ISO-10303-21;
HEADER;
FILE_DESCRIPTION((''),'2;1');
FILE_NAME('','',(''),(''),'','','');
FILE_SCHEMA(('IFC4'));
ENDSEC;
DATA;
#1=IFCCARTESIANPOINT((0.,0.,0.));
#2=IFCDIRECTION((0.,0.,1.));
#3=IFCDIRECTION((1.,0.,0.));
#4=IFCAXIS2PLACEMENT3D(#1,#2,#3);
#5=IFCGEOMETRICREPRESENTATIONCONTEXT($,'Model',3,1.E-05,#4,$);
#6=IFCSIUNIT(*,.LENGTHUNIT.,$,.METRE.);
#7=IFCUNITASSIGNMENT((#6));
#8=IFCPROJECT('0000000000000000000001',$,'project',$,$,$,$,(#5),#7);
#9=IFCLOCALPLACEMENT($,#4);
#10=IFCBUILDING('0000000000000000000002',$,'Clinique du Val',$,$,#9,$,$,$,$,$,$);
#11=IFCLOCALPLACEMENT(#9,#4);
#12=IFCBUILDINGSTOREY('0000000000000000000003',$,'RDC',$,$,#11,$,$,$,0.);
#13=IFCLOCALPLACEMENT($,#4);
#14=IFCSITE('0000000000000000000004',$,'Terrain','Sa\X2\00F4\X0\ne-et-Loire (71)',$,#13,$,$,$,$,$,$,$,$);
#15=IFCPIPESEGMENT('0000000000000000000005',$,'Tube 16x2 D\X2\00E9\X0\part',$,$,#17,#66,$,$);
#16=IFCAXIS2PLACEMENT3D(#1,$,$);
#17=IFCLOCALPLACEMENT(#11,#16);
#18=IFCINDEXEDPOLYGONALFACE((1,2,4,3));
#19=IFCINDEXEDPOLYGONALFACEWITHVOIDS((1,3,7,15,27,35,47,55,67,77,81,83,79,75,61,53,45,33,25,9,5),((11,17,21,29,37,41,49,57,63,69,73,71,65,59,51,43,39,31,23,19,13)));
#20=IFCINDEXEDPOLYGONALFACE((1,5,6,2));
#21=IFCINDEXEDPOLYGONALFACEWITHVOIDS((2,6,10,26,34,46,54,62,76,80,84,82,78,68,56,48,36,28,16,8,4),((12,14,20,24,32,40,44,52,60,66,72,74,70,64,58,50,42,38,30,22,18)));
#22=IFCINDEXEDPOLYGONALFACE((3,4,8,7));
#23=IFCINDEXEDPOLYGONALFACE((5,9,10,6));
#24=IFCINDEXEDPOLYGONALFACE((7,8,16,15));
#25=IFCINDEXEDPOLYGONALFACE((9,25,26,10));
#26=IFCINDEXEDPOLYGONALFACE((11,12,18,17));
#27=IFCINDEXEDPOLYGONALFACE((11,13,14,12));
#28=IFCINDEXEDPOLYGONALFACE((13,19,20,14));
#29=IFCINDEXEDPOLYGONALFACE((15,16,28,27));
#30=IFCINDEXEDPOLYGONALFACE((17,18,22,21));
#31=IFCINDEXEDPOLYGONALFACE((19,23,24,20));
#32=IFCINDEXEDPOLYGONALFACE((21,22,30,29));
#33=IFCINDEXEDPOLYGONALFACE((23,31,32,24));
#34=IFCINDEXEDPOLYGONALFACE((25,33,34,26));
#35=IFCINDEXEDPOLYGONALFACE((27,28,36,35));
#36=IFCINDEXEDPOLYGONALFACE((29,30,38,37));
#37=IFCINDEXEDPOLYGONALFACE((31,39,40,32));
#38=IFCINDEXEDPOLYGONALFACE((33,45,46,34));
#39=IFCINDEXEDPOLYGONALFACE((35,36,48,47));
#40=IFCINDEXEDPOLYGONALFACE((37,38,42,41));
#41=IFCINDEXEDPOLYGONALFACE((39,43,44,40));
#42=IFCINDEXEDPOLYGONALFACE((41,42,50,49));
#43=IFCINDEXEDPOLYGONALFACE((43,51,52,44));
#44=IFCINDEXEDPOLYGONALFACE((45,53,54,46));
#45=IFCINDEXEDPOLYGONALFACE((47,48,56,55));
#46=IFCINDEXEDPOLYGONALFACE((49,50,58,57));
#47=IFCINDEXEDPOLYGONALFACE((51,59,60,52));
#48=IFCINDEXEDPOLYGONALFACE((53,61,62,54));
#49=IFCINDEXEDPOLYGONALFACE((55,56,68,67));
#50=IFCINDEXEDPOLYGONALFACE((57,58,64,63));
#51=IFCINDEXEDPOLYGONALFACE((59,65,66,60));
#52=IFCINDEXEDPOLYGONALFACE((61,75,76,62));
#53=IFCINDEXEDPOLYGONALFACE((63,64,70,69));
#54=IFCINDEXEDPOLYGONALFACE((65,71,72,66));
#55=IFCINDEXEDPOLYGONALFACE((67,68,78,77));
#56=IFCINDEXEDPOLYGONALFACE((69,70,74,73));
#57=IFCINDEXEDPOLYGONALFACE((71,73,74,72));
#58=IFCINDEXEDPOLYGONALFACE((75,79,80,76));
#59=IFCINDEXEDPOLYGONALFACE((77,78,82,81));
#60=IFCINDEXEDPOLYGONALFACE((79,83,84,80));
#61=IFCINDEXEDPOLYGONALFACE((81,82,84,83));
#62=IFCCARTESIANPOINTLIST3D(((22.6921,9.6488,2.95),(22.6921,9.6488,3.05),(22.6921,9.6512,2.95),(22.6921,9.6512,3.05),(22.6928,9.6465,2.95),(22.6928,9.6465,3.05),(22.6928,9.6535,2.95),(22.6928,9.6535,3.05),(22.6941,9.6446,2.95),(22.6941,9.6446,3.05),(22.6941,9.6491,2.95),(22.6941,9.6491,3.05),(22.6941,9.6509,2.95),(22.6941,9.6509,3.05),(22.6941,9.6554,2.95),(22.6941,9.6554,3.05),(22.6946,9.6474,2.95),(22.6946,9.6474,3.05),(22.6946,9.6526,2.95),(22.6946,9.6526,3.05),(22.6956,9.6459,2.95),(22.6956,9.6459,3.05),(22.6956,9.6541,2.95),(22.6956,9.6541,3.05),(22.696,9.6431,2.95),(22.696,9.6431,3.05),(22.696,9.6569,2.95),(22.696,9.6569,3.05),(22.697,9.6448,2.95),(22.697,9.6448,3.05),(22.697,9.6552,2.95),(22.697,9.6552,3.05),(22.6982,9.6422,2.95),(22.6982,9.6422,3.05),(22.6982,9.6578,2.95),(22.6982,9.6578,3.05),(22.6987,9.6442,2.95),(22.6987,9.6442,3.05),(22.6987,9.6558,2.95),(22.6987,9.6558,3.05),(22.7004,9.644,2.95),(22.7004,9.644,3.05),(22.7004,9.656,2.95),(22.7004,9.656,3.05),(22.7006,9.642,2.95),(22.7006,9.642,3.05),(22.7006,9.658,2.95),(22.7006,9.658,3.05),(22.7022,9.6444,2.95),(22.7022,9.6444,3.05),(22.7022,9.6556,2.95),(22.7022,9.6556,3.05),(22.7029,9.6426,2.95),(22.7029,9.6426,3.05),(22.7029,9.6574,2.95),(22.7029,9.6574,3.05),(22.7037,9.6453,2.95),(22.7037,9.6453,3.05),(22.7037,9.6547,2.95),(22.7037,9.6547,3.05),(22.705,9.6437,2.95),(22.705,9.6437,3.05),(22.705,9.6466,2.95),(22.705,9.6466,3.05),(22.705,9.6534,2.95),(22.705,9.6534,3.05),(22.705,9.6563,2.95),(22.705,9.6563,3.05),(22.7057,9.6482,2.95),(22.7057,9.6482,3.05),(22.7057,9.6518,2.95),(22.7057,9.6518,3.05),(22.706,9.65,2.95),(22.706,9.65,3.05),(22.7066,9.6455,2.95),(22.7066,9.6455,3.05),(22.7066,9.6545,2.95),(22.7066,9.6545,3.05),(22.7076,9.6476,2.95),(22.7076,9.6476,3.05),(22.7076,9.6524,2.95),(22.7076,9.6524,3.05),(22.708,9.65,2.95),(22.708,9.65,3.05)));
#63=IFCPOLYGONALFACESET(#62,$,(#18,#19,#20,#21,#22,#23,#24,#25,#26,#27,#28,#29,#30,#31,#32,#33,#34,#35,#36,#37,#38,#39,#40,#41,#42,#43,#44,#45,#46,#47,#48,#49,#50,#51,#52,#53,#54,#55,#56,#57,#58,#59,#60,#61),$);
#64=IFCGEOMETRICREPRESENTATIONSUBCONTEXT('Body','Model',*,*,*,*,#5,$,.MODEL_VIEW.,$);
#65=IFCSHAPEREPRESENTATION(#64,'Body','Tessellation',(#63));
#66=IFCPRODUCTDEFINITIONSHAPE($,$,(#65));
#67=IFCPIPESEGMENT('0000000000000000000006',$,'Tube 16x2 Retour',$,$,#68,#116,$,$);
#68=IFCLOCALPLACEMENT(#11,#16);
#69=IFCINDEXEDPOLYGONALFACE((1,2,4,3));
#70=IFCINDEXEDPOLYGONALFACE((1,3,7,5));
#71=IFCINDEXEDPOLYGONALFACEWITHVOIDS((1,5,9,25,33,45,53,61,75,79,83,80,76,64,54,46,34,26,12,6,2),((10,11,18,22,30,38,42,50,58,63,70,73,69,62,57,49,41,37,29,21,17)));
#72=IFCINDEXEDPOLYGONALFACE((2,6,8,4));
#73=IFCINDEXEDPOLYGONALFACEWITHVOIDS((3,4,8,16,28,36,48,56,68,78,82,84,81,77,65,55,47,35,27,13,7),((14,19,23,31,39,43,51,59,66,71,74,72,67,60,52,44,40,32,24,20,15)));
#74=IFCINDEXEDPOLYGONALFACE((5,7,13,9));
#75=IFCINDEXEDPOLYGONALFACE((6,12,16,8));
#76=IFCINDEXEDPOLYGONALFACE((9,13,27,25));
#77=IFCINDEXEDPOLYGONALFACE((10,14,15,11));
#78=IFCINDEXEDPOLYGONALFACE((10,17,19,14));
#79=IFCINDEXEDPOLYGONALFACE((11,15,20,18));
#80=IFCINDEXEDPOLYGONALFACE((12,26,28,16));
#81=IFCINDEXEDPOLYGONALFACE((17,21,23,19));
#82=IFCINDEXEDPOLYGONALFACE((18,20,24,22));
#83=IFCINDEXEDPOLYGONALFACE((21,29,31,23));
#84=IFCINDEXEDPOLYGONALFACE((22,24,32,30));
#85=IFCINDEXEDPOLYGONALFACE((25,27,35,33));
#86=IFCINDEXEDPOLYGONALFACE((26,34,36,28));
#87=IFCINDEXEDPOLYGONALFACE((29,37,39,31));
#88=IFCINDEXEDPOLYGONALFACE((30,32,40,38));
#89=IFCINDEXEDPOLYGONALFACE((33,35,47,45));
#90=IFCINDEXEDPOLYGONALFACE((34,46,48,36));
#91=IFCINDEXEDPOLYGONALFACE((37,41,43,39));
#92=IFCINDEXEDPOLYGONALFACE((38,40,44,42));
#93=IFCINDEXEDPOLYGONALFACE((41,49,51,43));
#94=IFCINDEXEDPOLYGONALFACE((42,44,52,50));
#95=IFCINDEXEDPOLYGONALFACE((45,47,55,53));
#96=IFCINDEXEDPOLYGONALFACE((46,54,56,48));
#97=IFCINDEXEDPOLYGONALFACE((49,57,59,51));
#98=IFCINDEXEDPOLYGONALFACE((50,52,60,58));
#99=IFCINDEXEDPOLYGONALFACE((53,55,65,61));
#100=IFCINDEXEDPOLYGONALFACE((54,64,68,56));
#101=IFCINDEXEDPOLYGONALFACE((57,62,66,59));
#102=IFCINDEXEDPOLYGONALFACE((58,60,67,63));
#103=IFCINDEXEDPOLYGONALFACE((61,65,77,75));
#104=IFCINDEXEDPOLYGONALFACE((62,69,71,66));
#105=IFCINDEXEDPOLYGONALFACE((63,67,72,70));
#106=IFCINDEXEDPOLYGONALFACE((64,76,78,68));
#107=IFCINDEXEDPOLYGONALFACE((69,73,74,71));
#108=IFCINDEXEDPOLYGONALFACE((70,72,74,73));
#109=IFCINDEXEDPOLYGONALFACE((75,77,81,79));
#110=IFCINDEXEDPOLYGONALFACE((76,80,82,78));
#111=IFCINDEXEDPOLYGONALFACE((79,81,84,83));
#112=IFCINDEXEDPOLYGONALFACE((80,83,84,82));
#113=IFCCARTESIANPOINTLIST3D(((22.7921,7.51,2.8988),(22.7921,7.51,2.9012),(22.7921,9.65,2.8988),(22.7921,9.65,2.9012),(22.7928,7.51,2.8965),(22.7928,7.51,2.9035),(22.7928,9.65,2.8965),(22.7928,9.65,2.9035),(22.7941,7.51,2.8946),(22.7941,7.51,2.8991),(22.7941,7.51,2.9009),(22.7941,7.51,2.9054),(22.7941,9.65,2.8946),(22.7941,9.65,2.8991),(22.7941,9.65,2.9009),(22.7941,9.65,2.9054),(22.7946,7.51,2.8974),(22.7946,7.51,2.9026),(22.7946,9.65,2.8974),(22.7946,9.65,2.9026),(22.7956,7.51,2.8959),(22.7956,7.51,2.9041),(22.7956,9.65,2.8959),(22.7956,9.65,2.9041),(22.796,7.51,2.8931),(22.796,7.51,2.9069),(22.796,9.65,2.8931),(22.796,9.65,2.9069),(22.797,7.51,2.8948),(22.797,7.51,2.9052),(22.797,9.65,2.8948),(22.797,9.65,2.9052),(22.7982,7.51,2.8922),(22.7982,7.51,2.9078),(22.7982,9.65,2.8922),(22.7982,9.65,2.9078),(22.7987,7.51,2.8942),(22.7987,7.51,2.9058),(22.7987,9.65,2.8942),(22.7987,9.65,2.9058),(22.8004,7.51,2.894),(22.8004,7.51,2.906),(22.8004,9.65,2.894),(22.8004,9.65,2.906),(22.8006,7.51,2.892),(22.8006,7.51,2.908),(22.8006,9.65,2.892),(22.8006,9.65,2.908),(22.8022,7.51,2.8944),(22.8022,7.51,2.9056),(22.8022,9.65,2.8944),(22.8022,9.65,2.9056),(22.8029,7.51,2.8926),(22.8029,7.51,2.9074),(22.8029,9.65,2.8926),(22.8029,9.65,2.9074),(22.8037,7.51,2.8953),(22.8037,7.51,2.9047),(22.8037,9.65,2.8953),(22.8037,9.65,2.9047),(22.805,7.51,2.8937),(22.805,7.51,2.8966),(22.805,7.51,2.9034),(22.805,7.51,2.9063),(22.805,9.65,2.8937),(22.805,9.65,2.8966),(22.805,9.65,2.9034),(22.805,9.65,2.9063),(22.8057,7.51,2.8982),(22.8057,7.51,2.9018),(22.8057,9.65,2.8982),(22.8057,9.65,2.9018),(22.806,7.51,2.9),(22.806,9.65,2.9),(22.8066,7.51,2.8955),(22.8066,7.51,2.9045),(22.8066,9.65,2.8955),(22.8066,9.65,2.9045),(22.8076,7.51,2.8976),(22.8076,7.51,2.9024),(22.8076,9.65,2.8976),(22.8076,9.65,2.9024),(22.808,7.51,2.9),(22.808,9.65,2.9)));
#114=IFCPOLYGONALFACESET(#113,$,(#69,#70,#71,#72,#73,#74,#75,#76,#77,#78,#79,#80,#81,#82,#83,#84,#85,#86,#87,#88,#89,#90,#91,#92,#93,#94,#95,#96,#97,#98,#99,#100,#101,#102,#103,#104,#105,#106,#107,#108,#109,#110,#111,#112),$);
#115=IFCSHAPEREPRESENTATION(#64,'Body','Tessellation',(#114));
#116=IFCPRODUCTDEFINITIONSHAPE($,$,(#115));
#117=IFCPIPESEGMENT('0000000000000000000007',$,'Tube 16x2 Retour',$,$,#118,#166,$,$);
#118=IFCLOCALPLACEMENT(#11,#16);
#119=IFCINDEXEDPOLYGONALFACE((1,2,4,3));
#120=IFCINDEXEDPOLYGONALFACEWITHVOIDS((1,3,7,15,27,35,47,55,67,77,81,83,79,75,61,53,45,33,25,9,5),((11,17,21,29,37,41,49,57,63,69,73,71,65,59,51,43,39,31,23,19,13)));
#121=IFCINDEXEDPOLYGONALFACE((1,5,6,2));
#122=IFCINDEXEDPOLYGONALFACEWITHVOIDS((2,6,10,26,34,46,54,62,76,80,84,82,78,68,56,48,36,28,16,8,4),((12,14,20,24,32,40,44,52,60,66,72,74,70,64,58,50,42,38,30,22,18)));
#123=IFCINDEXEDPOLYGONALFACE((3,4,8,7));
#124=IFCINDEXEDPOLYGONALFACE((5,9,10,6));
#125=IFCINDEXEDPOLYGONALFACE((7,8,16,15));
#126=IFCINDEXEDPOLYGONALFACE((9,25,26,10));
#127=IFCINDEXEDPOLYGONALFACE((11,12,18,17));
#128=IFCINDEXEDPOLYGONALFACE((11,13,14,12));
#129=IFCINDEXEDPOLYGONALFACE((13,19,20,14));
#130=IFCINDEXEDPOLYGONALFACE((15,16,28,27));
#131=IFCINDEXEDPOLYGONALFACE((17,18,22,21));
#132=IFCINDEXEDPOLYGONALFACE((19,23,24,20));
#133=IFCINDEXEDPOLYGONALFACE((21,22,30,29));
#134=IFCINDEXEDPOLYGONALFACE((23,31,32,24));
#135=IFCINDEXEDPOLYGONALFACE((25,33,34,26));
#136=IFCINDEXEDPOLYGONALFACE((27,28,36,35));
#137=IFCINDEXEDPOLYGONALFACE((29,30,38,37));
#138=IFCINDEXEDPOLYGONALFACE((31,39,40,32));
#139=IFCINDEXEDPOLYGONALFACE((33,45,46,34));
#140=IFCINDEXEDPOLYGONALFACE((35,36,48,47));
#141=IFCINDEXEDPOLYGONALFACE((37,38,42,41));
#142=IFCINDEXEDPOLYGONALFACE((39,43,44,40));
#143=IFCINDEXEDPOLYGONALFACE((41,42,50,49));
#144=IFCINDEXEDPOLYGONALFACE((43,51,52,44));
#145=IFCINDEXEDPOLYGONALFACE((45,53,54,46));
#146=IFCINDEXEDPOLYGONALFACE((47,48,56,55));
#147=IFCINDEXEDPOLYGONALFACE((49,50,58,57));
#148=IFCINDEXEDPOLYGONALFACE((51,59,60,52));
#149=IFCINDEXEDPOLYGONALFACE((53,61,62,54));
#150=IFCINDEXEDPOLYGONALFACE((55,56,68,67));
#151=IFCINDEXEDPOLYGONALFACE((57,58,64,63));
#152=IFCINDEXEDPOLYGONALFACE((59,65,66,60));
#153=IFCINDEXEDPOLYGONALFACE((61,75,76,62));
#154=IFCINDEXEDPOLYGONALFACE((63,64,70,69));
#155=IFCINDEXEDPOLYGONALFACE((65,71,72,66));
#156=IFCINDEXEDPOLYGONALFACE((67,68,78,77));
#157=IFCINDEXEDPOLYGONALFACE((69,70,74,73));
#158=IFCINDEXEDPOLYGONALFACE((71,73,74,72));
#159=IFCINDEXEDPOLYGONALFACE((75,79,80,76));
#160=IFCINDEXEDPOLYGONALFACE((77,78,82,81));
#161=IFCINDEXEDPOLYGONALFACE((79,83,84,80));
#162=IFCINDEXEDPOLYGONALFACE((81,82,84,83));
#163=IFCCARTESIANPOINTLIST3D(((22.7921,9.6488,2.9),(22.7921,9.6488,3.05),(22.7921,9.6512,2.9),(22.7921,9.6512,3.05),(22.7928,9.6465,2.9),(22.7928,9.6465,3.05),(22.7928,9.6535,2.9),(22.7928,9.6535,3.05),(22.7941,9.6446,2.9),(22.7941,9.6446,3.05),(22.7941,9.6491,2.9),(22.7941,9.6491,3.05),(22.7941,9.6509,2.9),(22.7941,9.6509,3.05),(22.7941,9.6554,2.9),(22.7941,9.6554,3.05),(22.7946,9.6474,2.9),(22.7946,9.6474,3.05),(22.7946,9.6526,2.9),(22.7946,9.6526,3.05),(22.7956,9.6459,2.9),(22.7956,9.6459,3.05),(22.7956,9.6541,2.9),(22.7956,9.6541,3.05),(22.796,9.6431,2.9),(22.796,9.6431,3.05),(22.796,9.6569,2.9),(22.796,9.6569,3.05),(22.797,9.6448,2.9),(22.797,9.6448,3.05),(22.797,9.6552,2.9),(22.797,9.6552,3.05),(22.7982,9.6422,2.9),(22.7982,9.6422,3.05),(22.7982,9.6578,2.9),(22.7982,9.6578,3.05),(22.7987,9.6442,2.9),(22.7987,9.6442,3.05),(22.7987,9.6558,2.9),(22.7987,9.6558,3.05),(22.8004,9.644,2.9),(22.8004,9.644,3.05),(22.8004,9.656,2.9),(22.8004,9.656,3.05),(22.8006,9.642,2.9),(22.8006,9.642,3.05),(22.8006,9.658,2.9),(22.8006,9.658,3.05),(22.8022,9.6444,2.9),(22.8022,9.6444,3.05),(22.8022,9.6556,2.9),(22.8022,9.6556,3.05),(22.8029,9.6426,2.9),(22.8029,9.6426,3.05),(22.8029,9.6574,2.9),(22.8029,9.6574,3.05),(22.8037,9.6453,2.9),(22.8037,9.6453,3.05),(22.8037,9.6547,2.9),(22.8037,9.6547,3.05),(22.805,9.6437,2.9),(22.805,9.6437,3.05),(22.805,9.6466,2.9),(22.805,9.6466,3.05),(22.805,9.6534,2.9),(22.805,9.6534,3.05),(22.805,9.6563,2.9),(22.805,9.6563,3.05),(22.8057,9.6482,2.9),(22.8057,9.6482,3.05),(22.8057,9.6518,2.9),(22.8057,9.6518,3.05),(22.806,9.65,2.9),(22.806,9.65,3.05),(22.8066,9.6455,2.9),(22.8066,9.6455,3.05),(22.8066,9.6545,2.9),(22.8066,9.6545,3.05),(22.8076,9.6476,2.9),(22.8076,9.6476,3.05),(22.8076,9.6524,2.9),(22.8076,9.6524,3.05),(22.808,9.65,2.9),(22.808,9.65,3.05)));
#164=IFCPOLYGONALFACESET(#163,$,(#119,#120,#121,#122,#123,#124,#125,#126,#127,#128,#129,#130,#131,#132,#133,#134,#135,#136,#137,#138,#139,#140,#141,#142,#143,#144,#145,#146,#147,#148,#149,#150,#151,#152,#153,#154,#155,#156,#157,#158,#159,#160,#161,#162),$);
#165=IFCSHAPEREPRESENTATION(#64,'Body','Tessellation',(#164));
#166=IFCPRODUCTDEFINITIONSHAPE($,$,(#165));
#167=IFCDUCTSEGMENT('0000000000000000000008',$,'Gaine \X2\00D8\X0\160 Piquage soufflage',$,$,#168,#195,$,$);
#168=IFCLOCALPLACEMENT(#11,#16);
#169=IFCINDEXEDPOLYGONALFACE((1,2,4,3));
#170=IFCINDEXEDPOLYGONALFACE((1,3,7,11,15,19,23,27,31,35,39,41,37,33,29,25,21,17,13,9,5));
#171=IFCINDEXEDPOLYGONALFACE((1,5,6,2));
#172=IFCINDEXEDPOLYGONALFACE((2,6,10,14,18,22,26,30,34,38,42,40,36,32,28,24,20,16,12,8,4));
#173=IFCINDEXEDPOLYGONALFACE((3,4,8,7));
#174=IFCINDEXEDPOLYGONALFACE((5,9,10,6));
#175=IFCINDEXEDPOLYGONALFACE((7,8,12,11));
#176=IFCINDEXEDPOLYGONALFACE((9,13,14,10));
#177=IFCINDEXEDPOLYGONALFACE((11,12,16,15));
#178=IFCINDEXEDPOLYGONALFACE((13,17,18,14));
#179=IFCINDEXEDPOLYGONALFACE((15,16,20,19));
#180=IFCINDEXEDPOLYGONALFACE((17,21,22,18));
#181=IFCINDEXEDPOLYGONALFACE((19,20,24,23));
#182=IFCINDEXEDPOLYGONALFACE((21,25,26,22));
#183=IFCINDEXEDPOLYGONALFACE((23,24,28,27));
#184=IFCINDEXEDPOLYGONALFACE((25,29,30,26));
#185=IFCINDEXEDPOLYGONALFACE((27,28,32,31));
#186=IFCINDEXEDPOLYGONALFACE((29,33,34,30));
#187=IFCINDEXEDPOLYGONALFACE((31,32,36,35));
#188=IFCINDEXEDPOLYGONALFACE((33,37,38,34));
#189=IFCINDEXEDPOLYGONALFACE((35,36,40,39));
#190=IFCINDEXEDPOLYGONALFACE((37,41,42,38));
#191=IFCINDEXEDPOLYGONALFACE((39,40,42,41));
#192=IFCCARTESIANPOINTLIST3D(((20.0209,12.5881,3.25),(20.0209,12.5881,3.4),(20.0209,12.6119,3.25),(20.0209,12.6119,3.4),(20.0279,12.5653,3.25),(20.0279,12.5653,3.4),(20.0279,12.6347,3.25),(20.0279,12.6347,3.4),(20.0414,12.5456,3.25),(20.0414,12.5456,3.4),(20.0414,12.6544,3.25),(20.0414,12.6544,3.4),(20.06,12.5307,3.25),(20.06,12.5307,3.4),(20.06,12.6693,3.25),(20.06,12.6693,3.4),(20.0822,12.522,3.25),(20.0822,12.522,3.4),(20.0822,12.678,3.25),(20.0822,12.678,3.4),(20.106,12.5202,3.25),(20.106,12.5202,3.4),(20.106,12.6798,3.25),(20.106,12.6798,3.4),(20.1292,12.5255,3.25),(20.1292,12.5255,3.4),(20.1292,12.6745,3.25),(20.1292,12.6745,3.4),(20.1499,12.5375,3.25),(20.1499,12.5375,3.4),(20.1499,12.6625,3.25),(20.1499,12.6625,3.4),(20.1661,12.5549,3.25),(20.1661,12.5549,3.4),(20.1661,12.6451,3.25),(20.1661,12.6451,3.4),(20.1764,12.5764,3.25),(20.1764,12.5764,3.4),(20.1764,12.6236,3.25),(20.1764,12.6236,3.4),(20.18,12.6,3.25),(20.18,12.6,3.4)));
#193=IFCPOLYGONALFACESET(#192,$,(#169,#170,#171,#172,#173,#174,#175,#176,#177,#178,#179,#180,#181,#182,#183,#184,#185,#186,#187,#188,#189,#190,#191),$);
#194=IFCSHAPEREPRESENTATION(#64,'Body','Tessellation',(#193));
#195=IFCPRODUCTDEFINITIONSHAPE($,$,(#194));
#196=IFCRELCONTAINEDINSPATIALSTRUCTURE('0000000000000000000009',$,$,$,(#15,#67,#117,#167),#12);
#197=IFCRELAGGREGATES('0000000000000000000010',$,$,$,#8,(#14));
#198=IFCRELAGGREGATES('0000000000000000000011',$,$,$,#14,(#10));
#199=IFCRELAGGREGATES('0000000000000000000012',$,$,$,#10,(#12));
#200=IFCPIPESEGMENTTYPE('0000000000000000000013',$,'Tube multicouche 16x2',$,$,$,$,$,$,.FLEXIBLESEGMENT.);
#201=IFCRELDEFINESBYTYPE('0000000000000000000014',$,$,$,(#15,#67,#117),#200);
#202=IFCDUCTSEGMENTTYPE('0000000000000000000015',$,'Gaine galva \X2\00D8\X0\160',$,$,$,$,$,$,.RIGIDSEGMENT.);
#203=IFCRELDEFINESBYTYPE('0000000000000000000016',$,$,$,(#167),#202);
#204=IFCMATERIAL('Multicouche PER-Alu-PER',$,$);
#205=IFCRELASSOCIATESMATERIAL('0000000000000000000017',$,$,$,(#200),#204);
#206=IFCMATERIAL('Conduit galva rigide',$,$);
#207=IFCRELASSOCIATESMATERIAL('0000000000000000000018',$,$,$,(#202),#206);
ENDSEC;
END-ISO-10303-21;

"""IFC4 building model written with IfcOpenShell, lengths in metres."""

from ifc_helpers import new_model, si_unit, frame, origin_with_axes, place, context, subcontext, project, spatial, circle, hollow_circle, extrude, material, type_object, element, save


model = new_model("IFC4")

# Units and contexts
model_context = context("Model", 3, precision=1e-05, world=origin_with_axes())
body_context = subcontext(model_context, "Body", "Model", "MODEL_VIEW")
ifc_project = project(units=[si_unit("LENGTHUNIT", "METRE")], contexts=[model_context])

# Site, building, storey
site_placement = place(None, origin_with_axes())
site = spatial("IfcSite", under=ifc_project, at=site_placement, Name="Terrain", Description="Saône-et-Loire (71)")
building_placement = place(None, origin_with_axes())
building = spatial("IfcBuilding", under=site, at=building_placement, Name="Clinique du Val")
storey_placement = place(building_placement, origin_with_axes())
storey = spatial("IfcBuildingStorey", under=building, at=storey_placement, Name="RDC", Elevation=0.0)

# Pipe segments
ifc_material_1 = material(Name="Multicouche PER-Alu-PER")
pipe_segment_type = type_object("IfcPipeSegmentType", Name="Tube multicouche 16x2", PredefinedType="FLEXIBLESEGMENT", material=ifc_material_1)
pipe_segment_1_placement = place(storey_placement, frame((22.7, 9.65, 2.95), z_axis=(0.0, 0.0, 1.0), x_axis=(1.0, 0.0, 0.0)))
element("IfcPipeSegment", 1, at=pipe_segment_1_placement, inside=storey, type_object=pipe_segment_type, Name="Tube 16x2 Départ", context=body_context, shape_type="SweptSolid", body=[
    extrude(hollow_circle(Radius=0.008, WallThickness=0.002), origin_with_axes(), (0.0, 0.0, 1.0), 0.1),
])
pipe_segment_2_placement = place(storey_placement, frame((22.8, 7.51, 2.9), z_axis=(0.0, 1.0, 0.0), x_axis=(1.0, 0.0, 0.0)))
element("IfcPipeSegment", 2, at=pipe_segment_2_placement, inside=storey, type_object=pipe_segment_type, Name="Tube 16x2 Retour", context=body_context, shape_type="SweptSolid", body=[
    extrude(hollow_circle(Radius=0.008, WallThickness=0.002), origin_with_axes(), (0.0, 0.0, 1.0), 2.14),
])
pipe_segment_3_placement = place(storey_placement, frame((22.8, 9.65, 2.9), z_axis=(0.0, 0.0, 1.0), x_axis=(1.0, 0.0, 0.0)))
element("IfcPipeSegment", 3, at=pipe_segment_3_placement, inside=storey, type_object=pipe_segment_type, Name="Tube 16x2 Retour", context=body_context, shape_type="SweptSolid", body=[
    extrude(hollow_circle(Radius=0.008, WallThickness=0.002), origin_with_axes(), (0.0, 0.0, 1.0), 0.15),
])

# Duct segment
ifc_material_2 = material(Name="Conduit galva rigide")
duct_segment_type = type_object("IfcDuctSegmentType", Name="Gaine galva Ø160", PredefinedType="RIGIDSEGMENT", material=ifc_material_2)
duct_segment_1_placement = place(storey_placement, frame((20.1, 12.6, 3.4), z_axis=(0.0, 0.0, -1.0), x_axis=(1.0, 0.0, 0.0)))
element("IfcDuctSegment", 4, at=duct_segment_1_placement, inside=storey, type_object=duct_segment_type, Name="Gaine Ø160 Piquage soufflage", context=body_context, shape_type="SweptSolid", body=[
    extrude(circle(Radius=0.08), origin_with_axes(), (0.0, 0.0, 1.0), 0.15),
])

save(model, "model.ifc")
